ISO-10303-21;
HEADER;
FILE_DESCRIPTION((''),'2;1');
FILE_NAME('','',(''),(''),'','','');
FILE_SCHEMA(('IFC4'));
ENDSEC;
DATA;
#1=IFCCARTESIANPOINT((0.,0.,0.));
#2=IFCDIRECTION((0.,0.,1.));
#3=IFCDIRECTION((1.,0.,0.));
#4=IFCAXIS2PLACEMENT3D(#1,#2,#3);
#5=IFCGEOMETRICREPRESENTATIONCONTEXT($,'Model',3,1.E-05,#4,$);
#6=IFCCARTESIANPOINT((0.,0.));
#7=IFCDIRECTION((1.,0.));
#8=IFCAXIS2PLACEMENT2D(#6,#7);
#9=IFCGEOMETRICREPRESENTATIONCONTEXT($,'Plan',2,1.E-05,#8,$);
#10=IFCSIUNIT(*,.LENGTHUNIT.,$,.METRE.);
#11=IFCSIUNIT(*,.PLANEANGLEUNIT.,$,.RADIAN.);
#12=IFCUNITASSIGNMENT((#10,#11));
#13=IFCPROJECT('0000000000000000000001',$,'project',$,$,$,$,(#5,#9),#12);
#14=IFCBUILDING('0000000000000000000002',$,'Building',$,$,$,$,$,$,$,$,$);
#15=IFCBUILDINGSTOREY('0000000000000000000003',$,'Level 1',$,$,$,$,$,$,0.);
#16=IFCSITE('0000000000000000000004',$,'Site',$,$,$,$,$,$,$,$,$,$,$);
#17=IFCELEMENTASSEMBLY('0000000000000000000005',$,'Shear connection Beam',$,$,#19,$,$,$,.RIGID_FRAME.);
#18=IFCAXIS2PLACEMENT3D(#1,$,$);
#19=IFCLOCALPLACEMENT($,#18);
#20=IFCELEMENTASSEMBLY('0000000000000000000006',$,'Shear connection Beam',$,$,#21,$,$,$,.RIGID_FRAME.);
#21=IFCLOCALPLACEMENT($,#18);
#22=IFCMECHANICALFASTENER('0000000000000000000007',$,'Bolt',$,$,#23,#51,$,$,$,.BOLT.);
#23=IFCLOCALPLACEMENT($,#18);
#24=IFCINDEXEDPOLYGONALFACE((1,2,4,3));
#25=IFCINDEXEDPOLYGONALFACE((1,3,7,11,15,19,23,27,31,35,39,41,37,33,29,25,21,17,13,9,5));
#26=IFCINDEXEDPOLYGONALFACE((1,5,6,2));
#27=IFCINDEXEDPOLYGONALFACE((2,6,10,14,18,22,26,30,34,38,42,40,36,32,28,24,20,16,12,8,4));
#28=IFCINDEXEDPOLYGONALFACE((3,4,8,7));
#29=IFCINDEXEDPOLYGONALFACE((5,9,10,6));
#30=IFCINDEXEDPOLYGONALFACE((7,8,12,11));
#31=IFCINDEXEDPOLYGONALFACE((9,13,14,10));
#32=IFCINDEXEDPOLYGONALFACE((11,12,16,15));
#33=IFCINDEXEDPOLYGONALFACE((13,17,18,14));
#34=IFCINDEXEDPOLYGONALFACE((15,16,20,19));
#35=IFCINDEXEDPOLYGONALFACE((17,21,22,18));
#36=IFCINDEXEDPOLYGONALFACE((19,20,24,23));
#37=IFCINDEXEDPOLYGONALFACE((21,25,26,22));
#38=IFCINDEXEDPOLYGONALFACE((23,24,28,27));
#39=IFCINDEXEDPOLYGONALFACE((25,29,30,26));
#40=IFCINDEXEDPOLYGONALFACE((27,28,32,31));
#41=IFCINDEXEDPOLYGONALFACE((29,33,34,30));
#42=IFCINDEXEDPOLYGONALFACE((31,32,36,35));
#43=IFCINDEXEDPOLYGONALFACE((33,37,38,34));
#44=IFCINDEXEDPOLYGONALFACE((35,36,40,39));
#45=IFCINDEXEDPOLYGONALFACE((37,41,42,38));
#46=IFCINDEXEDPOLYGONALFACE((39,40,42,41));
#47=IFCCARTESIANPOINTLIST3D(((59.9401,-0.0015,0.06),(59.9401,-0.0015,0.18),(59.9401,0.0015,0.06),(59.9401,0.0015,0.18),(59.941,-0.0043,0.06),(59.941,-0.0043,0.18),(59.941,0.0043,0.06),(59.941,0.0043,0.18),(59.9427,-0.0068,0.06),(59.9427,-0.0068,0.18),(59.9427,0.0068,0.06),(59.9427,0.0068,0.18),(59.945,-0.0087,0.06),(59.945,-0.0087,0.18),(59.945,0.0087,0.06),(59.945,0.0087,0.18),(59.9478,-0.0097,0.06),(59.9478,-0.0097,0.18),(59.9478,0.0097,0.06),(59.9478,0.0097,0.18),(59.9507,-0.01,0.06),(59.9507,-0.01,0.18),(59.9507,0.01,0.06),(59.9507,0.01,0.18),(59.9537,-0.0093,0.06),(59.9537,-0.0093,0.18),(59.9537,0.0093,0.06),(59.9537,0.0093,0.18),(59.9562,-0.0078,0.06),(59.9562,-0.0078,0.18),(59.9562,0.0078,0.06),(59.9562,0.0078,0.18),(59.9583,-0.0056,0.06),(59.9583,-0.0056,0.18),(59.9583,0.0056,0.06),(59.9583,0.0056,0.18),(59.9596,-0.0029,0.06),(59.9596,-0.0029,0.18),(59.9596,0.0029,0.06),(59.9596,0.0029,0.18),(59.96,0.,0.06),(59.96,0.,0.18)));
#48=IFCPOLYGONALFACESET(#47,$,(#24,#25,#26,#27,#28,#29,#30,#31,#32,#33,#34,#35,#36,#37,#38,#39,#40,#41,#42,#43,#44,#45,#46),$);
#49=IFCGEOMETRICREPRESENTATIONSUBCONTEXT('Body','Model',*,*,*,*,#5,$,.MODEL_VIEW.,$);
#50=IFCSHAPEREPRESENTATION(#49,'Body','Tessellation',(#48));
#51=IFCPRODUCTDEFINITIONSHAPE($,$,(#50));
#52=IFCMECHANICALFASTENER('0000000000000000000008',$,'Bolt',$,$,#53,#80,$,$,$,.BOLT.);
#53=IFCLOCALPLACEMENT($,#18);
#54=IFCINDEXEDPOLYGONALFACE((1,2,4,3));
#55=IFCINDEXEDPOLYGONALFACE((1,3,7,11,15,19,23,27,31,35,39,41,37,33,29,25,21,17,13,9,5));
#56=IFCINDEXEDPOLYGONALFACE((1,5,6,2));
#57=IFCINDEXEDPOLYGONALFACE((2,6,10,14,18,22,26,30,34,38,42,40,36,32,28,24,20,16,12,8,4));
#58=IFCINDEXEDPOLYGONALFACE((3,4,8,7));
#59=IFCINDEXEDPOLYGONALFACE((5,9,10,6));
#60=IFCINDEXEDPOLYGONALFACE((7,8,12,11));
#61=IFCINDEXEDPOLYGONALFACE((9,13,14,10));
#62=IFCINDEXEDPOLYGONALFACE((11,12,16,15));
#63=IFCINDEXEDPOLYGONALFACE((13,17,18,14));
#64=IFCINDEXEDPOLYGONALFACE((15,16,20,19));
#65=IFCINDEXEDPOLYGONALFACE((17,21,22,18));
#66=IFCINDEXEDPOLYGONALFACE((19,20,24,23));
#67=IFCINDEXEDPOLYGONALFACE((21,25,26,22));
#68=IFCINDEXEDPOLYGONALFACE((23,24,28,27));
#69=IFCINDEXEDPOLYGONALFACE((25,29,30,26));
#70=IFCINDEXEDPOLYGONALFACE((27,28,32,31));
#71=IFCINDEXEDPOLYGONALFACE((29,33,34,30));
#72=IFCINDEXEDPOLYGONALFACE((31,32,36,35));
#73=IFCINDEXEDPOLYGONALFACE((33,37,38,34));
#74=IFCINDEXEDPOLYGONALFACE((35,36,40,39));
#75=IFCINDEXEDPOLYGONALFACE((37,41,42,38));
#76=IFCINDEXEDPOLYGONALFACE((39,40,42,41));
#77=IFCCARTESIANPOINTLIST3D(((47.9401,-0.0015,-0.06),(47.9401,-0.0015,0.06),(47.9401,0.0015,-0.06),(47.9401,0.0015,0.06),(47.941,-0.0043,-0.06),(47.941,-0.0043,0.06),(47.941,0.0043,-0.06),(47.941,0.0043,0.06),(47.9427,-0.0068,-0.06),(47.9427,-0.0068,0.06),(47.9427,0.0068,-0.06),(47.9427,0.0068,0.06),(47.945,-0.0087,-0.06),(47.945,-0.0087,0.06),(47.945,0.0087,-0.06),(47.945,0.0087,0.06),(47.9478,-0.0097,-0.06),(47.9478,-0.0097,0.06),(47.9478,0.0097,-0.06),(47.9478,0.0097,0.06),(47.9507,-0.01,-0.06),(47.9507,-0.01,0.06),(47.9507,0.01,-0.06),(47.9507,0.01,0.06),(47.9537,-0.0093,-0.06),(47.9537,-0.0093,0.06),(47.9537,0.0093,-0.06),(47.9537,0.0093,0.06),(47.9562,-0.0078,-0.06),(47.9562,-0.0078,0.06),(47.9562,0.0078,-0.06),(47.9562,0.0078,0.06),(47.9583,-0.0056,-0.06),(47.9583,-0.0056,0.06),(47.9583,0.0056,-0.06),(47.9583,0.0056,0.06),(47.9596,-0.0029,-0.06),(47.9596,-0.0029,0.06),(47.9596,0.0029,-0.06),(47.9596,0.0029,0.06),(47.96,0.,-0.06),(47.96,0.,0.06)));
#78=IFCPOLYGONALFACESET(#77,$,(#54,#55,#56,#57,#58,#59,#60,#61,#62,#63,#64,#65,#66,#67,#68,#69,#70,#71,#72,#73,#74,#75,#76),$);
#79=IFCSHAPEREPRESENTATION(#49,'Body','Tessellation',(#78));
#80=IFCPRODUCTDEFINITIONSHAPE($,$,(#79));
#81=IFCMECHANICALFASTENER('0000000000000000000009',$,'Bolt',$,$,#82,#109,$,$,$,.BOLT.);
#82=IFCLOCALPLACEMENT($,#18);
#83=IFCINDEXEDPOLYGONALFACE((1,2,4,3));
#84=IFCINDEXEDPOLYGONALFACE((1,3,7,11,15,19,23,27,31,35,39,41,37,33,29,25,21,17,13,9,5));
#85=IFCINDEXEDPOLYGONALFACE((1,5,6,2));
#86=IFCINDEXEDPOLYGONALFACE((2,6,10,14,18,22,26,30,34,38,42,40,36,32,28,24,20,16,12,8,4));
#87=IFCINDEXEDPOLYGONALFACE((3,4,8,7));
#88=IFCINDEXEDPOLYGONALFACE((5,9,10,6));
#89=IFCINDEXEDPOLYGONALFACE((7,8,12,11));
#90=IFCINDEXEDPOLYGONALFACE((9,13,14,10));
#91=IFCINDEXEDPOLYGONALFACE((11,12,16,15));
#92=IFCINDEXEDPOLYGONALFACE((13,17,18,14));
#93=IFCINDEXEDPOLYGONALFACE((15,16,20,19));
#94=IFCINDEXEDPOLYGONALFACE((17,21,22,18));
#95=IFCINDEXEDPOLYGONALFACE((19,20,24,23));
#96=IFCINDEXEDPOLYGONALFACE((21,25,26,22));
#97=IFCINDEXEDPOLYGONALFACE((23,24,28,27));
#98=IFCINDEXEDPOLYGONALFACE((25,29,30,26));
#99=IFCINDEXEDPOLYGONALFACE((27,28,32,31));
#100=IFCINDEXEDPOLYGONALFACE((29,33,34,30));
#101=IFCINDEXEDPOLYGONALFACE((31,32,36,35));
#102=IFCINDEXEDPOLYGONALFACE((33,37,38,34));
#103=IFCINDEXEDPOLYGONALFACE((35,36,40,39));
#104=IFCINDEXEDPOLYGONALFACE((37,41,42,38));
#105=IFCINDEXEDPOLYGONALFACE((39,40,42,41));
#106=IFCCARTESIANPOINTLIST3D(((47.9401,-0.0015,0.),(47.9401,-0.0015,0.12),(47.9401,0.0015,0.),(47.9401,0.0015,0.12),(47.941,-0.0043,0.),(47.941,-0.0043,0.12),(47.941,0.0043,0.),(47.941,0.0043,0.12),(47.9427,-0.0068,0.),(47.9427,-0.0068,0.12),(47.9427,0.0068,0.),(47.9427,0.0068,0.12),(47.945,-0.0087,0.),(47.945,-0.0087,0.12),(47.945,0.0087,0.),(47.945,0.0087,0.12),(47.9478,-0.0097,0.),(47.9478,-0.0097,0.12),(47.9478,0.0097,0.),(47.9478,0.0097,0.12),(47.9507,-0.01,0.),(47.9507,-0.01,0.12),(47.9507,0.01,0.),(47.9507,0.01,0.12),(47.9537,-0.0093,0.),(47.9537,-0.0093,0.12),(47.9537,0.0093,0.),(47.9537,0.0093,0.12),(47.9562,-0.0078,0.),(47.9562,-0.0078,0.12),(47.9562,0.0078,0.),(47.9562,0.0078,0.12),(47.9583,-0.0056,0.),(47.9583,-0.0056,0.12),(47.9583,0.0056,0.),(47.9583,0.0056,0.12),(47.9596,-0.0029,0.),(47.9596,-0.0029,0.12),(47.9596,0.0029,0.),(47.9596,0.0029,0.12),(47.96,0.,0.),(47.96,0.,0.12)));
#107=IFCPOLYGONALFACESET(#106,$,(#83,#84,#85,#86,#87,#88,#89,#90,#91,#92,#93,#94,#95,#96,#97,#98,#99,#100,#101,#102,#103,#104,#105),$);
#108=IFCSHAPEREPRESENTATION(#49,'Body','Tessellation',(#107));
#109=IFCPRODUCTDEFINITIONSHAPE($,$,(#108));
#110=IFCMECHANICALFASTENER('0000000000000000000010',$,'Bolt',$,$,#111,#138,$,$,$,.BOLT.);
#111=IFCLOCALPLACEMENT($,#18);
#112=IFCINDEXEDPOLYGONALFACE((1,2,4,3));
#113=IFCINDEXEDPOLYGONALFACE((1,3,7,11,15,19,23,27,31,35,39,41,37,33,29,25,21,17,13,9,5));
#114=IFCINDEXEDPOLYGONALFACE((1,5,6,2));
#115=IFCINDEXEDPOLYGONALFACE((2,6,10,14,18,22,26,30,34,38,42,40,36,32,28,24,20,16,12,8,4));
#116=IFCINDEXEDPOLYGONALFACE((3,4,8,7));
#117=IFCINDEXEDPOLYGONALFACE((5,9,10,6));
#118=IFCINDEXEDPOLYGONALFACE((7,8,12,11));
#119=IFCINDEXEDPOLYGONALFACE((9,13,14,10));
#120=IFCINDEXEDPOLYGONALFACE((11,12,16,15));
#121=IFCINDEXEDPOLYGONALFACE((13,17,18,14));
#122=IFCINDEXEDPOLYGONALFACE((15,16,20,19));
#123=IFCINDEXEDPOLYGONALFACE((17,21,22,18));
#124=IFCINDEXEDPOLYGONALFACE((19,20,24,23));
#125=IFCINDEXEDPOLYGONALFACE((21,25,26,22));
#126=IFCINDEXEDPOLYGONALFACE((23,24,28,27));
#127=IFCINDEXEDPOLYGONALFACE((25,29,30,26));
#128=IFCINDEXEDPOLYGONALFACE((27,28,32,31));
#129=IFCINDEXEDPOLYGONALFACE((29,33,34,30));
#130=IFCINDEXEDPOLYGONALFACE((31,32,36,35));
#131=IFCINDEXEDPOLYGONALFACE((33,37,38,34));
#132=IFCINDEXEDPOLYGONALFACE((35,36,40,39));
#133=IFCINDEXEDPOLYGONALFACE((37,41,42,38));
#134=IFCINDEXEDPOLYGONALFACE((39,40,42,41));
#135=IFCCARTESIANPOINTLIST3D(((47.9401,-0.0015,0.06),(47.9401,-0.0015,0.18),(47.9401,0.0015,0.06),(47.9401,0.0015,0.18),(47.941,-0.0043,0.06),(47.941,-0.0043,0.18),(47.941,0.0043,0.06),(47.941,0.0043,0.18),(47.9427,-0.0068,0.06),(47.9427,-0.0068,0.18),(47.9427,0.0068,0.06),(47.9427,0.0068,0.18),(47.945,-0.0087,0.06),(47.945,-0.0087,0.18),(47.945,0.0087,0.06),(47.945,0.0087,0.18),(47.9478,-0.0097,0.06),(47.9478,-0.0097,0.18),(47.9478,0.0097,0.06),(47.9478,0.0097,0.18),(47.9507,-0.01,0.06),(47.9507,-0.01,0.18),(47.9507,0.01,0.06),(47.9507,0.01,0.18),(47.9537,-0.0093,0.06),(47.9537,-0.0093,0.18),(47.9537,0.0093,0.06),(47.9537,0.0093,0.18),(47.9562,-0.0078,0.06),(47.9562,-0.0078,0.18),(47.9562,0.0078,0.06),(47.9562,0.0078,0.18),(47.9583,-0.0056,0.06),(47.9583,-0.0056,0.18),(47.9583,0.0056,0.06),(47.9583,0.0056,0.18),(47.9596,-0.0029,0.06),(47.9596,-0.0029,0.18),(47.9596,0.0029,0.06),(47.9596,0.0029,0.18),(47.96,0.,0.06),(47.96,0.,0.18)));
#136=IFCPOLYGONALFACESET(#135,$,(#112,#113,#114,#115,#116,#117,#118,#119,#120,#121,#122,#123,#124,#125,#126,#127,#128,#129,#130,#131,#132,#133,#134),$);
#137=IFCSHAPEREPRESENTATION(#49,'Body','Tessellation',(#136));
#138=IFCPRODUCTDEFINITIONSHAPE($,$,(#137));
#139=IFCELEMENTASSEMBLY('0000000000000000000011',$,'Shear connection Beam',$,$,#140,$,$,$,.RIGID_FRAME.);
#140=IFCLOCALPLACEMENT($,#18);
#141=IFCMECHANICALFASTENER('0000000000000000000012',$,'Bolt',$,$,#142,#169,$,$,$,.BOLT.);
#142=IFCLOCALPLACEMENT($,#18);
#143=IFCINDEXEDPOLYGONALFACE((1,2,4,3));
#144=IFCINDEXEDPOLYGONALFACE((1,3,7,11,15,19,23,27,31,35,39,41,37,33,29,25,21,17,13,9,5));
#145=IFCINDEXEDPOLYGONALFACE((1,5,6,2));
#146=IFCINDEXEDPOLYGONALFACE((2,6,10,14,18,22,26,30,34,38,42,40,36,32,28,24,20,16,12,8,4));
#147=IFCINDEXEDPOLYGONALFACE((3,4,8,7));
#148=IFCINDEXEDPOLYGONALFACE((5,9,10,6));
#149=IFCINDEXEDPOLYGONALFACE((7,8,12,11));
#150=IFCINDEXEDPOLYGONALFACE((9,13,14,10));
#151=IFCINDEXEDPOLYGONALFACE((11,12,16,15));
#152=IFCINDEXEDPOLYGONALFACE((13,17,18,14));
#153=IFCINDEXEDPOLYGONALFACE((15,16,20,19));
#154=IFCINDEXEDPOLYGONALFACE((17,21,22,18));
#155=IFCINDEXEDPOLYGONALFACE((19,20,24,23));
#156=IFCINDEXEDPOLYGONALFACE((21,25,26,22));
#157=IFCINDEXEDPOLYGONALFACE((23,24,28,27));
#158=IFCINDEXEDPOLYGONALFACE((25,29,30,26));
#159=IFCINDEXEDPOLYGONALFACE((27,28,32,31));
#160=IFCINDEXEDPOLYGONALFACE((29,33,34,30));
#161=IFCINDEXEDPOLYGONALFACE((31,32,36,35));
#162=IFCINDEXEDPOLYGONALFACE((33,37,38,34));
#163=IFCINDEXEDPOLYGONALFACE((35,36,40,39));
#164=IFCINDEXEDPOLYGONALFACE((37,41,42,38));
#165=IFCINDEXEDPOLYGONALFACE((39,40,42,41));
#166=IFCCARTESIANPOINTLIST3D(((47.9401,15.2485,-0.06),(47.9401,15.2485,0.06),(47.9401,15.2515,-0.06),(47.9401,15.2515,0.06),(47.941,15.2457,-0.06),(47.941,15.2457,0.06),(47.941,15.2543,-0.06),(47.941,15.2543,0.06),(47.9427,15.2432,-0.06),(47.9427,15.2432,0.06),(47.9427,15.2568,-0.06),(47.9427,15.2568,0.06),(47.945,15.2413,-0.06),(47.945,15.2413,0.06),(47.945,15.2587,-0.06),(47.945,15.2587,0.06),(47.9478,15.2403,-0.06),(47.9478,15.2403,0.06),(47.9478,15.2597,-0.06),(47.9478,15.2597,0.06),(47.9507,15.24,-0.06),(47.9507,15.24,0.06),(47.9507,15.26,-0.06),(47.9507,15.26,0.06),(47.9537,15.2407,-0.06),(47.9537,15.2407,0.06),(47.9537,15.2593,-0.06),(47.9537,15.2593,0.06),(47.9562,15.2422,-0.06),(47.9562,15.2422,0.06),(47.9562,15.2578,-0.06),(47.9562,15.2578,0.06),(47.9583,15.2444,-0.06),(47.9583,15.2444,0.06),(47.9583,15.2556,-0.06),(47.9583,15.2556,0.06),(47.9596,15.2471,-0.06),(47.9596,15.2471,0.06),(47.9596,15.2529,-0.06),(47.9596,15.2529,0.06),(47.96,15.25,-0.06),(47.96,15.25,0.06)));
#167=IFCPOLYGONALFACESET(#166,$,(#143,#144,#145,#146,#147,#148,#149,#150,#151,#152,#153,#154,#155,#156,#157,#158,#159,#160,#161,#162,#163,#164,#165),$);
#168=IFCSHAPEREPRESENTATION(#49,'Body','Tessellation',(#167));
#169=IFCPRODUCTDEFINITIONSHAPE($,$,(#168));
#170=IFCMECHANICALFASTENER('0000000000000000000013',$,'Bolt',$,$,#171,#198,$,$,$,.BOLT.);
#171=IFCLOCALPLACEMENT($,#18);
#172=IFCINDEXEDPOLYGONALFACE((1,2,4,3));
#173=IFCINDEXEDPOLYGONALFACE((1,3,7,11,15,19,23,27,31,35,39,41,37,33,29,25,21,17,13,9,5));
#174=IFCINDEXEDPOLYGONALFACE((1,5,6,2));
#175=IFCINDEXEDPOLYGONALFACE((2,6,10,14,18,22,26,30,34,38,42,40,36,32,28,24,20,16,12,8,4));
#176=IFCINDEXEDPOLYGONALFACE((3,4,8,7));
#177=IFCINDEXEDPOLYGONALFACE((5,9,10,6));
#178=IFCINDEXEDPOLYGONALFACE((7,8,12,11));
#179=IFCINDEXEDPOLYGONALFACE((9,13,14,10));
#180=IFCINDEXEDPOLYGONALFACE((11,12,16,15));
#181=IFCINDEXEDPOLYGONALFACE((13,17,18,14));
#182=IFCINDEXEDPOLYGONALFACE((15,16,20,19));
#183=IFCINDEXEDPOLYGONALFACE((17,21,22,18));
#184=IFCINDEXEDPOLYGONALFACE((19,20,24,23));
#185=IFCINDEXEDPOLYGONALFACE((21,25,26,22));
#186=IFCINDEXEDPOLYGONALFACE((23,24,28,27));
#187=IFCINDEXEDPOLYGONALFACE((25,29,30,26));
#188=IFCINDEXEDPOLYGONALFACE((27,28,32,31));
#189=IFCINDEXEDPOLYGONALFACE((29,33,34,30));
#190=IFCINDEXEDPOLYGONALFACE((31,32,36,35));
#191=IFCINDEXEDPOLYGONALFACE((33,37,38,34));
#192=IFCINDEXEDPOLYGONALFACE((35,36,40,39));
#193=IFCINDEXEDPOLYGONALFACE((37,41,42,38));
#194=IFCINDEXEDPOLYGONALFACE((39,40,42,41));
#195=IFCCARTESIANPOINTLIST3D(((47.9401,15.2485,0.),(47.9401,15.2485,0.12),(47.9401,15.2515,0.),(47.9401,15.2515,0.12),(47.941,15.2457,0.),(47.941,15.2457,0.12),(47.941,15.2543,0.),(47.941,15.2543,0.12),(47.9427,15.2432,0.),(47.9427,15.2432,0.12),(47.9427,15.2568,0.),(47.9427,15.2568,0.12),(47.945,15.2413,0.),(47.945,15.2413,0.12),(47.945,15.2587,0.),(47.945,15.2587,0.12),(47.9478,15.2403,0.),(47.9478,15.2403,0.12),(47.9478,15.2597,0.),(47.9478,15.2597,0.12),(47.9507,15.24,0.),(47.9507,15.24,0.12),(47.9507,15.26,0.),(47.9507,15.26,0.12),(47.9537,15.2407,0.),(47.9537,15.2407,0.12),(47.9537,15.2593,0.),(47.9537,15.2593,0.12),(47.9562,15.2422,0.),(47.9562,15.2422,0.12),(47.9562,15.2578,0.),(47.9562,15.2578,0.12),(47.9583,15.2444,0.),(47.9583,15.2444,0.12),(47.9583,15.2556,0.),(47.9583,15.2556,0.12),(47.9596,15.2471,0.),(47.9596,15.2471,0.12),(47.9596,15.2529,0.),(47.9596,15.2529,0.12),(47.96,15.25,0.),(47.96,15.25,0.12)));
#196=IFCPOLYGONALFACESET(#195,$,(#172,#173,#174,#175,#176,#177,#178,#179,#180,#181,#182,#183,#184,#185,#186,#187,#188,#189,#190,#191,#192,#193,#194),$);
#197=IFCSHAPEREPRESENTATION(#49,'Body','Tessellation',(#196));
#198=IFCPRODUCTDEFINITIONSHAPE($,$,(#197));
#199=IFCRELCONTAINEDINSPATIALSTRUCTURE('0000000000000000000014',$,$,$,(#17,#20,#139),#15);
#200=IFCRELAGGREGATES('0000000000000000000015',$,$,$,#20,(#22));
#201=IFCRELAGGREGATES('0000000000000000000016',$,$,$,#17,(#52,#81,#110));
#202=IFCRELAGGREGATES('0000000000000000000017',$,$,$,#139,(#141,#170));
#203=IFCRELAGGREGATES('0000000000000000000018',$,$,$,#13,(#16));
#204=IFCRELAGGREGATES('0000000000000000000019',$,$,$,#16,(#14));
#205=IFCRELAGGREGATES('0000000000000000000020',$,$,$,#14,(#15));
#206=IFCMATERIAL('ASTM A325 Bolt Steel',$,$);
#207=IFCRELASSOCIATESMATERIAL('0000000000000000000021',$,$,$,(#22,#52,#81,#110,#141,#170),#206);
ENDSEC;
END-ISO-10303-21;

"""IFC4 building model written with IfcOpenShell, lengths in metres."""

from ifc_helpers import new_model, si_unit, frame, origin_with_axes, origin_2d, origin_2d_with_axis, place, context, subcontext, project, spatial, circle, extrude, material, element, aggregate, save


model = new_model("IFC4")

# Units and contexts
model_context = context("Model", 3, precision=1e-05, world=origin_with_axes())
plan_context = context("Plan", 2, precision=1e-05, world=origin_2d_with_axis())
body_context = subcontext(model_context, "Body", "Model", "MODEL_VIEW")
ifc_project = project(units=[si_unit("LENGTHUNIT", "METRE"), si_unit("PLANEANGLEUNIT", "RADIAN")], contexts=[model_context, plan_context])

# Site, building, storey
site = spatial("IfcSite", under=ifc_project, Name="Site")
building = spatial("IfcBuilding", under=site, Name="Building")
storey = spatial("IfcBuildingStorey", under=building, Name="Level 1", Elevation=0.0)

# Element assembly
assembly_1 = element("IfcElementAssembly", 1, inside=storey, Name="Shear connection Beam", PredefinedType="RIGID_FRAME")

# Shared definitions
ifc_material_1 = material(Name="ASTM A325 Bolt Steel")

# Element assembly, mechanical fastener
assembly_2 = element("IfcElementAssembly", 2, inside=storey, Name="Shear connection Beam", PredefinedType="RIGID_FRAME")
mechanical_fastener_1_placement = place(None, frame((59.95, 0.0, 0.06), z_axis=(0.0, 0.0, 1.0), x_axis=(1.0, 0.0, 0.0)))
mechanical_fastener_1 = element("IfcMechanicalFastener", 3, at=mechanical_fastener_1_placement, material=ifc_material_1, Name="Bolt", PredefinedType="BOLT", context=body_context, shape_type="SweptSolid", body=[
    extrude(circle(Radius=0.01, at=origin_2d()), origin_with_axes(), (0.0, 0.0, 1.0), 0.12),
])
aggregate(assembly_2, [mechanical_fastener_1])

# Mechanical fasteners
mechanical_fastener_2_placement = place(None, frame((47.95, 0.0, -0.06), z_axis=(0.0, 0.0, 1.0), x_axis=(1.0, 0.0, 0.0)))
mechanical_fastener_2 = element("IfcMechanicalFastener", 4, at=mechanical_fastener_2_placement, material=ifc_material_1, Name="Bolt", PredefinedType="BOLT", context=body_context, shape_type="SweptSolid", body=[
    extrude(circle(Radius=0.01, at=origin_2d()), origin_with_axes(), (0.0, 0.0, 1.0), 0.12),
])
mechanical_fastener_3_placement = place(None, frame((47.95, 0.0, 0.0), z_axis=(0.0, 0.0, 1.0), x_axis=(1.0, 0.0, 0.0)))
mechanical_fastener_3 = element("IfcMechanicalFastener", 5, at=mechanical_fastener_3_placement, material=ifc_material_1, Name="Bolt", PredefinedType="BOLT", context=body_context, shape_type="SweptSolid", body=[
    extrude(circle(Radius=0.01, at=origin_2d()), origin_with_axes(), (0.0, 0.0, 1.0), 0.12),
])
mechanical_fastener_4_placement = place(None, frame((47.95, 0.0, 0.06), z_axis=(0.0, 0.0, 1.0), x_axis=(1.0, 0.0, 0.0)))
mechanical_fastener_4 = element("IfcMechanicalFastener", 6, at=mechanical_fastener_4_placement, material=ifc_material_1, Name="Bolt", PredefinedType="BOLT", context=body_context, shape_type="SweptSolid", body=[
    extrude(circle(Radius=0.01, at=origin_2d()), origin_with_axes(), (0.0, 0.0, 1.0), 0.12),
])
aggregate(assembly_1, [mechanical_fastener_2, mechanical_fastener_3, mechanical_fastener_4])

# Element assembly, mechanical fasteners
assembly_3 = element("IfcElementAssembly", 7, inside=storey, Name="Shear connection Beam", PredefinedType="RIGID_FRAME")
mechanical_fastener_5_placement = place(None, frame((47.95, 15.25, -0.06), z_axis=(0.0, 0.0, 1.0), x_axis=(1.0, 0.0, 0.0)))
mechanical_fastener_5 = element("IfcMechanicalFastener", 8, at=mechanical_fastener_5_placement, material=ifc_material_1, Name="Bolt", PredefinedType="BOLT", context=body_context, shape_type="SweptSolid", body=[
    extrude(circle(Radius=0.01, at=origin_2d()), origin_with_axes(), (0.0, 0.0, 1.0), 0.12),
])
mechanical_fastener_6_placement = place(None, frame((47.95, 15.25, 0.0), z_axis=(0.0, 0.0, 1.0), x_axis=(1.0, 0.0, 0.0)))
mechanical_fastener_6 = element("IfcMechanicalFastener", 9, at=mechanical_fastener_6_placement, material=ifc_material_1, Name="Bolt", PredefinedType="BOLT", context=body_context, shape_type="SweptSolid", body=[
    extrude(circle(Radius=0.01, at=origin_2d()), origin_with_axes(), (0.0, 0.0, 1.0), 0.12),
])
aggregate(assembly_3, [mechanical_fastener_5, mechanical_fastener_6])

save(model, "model.ifc")
